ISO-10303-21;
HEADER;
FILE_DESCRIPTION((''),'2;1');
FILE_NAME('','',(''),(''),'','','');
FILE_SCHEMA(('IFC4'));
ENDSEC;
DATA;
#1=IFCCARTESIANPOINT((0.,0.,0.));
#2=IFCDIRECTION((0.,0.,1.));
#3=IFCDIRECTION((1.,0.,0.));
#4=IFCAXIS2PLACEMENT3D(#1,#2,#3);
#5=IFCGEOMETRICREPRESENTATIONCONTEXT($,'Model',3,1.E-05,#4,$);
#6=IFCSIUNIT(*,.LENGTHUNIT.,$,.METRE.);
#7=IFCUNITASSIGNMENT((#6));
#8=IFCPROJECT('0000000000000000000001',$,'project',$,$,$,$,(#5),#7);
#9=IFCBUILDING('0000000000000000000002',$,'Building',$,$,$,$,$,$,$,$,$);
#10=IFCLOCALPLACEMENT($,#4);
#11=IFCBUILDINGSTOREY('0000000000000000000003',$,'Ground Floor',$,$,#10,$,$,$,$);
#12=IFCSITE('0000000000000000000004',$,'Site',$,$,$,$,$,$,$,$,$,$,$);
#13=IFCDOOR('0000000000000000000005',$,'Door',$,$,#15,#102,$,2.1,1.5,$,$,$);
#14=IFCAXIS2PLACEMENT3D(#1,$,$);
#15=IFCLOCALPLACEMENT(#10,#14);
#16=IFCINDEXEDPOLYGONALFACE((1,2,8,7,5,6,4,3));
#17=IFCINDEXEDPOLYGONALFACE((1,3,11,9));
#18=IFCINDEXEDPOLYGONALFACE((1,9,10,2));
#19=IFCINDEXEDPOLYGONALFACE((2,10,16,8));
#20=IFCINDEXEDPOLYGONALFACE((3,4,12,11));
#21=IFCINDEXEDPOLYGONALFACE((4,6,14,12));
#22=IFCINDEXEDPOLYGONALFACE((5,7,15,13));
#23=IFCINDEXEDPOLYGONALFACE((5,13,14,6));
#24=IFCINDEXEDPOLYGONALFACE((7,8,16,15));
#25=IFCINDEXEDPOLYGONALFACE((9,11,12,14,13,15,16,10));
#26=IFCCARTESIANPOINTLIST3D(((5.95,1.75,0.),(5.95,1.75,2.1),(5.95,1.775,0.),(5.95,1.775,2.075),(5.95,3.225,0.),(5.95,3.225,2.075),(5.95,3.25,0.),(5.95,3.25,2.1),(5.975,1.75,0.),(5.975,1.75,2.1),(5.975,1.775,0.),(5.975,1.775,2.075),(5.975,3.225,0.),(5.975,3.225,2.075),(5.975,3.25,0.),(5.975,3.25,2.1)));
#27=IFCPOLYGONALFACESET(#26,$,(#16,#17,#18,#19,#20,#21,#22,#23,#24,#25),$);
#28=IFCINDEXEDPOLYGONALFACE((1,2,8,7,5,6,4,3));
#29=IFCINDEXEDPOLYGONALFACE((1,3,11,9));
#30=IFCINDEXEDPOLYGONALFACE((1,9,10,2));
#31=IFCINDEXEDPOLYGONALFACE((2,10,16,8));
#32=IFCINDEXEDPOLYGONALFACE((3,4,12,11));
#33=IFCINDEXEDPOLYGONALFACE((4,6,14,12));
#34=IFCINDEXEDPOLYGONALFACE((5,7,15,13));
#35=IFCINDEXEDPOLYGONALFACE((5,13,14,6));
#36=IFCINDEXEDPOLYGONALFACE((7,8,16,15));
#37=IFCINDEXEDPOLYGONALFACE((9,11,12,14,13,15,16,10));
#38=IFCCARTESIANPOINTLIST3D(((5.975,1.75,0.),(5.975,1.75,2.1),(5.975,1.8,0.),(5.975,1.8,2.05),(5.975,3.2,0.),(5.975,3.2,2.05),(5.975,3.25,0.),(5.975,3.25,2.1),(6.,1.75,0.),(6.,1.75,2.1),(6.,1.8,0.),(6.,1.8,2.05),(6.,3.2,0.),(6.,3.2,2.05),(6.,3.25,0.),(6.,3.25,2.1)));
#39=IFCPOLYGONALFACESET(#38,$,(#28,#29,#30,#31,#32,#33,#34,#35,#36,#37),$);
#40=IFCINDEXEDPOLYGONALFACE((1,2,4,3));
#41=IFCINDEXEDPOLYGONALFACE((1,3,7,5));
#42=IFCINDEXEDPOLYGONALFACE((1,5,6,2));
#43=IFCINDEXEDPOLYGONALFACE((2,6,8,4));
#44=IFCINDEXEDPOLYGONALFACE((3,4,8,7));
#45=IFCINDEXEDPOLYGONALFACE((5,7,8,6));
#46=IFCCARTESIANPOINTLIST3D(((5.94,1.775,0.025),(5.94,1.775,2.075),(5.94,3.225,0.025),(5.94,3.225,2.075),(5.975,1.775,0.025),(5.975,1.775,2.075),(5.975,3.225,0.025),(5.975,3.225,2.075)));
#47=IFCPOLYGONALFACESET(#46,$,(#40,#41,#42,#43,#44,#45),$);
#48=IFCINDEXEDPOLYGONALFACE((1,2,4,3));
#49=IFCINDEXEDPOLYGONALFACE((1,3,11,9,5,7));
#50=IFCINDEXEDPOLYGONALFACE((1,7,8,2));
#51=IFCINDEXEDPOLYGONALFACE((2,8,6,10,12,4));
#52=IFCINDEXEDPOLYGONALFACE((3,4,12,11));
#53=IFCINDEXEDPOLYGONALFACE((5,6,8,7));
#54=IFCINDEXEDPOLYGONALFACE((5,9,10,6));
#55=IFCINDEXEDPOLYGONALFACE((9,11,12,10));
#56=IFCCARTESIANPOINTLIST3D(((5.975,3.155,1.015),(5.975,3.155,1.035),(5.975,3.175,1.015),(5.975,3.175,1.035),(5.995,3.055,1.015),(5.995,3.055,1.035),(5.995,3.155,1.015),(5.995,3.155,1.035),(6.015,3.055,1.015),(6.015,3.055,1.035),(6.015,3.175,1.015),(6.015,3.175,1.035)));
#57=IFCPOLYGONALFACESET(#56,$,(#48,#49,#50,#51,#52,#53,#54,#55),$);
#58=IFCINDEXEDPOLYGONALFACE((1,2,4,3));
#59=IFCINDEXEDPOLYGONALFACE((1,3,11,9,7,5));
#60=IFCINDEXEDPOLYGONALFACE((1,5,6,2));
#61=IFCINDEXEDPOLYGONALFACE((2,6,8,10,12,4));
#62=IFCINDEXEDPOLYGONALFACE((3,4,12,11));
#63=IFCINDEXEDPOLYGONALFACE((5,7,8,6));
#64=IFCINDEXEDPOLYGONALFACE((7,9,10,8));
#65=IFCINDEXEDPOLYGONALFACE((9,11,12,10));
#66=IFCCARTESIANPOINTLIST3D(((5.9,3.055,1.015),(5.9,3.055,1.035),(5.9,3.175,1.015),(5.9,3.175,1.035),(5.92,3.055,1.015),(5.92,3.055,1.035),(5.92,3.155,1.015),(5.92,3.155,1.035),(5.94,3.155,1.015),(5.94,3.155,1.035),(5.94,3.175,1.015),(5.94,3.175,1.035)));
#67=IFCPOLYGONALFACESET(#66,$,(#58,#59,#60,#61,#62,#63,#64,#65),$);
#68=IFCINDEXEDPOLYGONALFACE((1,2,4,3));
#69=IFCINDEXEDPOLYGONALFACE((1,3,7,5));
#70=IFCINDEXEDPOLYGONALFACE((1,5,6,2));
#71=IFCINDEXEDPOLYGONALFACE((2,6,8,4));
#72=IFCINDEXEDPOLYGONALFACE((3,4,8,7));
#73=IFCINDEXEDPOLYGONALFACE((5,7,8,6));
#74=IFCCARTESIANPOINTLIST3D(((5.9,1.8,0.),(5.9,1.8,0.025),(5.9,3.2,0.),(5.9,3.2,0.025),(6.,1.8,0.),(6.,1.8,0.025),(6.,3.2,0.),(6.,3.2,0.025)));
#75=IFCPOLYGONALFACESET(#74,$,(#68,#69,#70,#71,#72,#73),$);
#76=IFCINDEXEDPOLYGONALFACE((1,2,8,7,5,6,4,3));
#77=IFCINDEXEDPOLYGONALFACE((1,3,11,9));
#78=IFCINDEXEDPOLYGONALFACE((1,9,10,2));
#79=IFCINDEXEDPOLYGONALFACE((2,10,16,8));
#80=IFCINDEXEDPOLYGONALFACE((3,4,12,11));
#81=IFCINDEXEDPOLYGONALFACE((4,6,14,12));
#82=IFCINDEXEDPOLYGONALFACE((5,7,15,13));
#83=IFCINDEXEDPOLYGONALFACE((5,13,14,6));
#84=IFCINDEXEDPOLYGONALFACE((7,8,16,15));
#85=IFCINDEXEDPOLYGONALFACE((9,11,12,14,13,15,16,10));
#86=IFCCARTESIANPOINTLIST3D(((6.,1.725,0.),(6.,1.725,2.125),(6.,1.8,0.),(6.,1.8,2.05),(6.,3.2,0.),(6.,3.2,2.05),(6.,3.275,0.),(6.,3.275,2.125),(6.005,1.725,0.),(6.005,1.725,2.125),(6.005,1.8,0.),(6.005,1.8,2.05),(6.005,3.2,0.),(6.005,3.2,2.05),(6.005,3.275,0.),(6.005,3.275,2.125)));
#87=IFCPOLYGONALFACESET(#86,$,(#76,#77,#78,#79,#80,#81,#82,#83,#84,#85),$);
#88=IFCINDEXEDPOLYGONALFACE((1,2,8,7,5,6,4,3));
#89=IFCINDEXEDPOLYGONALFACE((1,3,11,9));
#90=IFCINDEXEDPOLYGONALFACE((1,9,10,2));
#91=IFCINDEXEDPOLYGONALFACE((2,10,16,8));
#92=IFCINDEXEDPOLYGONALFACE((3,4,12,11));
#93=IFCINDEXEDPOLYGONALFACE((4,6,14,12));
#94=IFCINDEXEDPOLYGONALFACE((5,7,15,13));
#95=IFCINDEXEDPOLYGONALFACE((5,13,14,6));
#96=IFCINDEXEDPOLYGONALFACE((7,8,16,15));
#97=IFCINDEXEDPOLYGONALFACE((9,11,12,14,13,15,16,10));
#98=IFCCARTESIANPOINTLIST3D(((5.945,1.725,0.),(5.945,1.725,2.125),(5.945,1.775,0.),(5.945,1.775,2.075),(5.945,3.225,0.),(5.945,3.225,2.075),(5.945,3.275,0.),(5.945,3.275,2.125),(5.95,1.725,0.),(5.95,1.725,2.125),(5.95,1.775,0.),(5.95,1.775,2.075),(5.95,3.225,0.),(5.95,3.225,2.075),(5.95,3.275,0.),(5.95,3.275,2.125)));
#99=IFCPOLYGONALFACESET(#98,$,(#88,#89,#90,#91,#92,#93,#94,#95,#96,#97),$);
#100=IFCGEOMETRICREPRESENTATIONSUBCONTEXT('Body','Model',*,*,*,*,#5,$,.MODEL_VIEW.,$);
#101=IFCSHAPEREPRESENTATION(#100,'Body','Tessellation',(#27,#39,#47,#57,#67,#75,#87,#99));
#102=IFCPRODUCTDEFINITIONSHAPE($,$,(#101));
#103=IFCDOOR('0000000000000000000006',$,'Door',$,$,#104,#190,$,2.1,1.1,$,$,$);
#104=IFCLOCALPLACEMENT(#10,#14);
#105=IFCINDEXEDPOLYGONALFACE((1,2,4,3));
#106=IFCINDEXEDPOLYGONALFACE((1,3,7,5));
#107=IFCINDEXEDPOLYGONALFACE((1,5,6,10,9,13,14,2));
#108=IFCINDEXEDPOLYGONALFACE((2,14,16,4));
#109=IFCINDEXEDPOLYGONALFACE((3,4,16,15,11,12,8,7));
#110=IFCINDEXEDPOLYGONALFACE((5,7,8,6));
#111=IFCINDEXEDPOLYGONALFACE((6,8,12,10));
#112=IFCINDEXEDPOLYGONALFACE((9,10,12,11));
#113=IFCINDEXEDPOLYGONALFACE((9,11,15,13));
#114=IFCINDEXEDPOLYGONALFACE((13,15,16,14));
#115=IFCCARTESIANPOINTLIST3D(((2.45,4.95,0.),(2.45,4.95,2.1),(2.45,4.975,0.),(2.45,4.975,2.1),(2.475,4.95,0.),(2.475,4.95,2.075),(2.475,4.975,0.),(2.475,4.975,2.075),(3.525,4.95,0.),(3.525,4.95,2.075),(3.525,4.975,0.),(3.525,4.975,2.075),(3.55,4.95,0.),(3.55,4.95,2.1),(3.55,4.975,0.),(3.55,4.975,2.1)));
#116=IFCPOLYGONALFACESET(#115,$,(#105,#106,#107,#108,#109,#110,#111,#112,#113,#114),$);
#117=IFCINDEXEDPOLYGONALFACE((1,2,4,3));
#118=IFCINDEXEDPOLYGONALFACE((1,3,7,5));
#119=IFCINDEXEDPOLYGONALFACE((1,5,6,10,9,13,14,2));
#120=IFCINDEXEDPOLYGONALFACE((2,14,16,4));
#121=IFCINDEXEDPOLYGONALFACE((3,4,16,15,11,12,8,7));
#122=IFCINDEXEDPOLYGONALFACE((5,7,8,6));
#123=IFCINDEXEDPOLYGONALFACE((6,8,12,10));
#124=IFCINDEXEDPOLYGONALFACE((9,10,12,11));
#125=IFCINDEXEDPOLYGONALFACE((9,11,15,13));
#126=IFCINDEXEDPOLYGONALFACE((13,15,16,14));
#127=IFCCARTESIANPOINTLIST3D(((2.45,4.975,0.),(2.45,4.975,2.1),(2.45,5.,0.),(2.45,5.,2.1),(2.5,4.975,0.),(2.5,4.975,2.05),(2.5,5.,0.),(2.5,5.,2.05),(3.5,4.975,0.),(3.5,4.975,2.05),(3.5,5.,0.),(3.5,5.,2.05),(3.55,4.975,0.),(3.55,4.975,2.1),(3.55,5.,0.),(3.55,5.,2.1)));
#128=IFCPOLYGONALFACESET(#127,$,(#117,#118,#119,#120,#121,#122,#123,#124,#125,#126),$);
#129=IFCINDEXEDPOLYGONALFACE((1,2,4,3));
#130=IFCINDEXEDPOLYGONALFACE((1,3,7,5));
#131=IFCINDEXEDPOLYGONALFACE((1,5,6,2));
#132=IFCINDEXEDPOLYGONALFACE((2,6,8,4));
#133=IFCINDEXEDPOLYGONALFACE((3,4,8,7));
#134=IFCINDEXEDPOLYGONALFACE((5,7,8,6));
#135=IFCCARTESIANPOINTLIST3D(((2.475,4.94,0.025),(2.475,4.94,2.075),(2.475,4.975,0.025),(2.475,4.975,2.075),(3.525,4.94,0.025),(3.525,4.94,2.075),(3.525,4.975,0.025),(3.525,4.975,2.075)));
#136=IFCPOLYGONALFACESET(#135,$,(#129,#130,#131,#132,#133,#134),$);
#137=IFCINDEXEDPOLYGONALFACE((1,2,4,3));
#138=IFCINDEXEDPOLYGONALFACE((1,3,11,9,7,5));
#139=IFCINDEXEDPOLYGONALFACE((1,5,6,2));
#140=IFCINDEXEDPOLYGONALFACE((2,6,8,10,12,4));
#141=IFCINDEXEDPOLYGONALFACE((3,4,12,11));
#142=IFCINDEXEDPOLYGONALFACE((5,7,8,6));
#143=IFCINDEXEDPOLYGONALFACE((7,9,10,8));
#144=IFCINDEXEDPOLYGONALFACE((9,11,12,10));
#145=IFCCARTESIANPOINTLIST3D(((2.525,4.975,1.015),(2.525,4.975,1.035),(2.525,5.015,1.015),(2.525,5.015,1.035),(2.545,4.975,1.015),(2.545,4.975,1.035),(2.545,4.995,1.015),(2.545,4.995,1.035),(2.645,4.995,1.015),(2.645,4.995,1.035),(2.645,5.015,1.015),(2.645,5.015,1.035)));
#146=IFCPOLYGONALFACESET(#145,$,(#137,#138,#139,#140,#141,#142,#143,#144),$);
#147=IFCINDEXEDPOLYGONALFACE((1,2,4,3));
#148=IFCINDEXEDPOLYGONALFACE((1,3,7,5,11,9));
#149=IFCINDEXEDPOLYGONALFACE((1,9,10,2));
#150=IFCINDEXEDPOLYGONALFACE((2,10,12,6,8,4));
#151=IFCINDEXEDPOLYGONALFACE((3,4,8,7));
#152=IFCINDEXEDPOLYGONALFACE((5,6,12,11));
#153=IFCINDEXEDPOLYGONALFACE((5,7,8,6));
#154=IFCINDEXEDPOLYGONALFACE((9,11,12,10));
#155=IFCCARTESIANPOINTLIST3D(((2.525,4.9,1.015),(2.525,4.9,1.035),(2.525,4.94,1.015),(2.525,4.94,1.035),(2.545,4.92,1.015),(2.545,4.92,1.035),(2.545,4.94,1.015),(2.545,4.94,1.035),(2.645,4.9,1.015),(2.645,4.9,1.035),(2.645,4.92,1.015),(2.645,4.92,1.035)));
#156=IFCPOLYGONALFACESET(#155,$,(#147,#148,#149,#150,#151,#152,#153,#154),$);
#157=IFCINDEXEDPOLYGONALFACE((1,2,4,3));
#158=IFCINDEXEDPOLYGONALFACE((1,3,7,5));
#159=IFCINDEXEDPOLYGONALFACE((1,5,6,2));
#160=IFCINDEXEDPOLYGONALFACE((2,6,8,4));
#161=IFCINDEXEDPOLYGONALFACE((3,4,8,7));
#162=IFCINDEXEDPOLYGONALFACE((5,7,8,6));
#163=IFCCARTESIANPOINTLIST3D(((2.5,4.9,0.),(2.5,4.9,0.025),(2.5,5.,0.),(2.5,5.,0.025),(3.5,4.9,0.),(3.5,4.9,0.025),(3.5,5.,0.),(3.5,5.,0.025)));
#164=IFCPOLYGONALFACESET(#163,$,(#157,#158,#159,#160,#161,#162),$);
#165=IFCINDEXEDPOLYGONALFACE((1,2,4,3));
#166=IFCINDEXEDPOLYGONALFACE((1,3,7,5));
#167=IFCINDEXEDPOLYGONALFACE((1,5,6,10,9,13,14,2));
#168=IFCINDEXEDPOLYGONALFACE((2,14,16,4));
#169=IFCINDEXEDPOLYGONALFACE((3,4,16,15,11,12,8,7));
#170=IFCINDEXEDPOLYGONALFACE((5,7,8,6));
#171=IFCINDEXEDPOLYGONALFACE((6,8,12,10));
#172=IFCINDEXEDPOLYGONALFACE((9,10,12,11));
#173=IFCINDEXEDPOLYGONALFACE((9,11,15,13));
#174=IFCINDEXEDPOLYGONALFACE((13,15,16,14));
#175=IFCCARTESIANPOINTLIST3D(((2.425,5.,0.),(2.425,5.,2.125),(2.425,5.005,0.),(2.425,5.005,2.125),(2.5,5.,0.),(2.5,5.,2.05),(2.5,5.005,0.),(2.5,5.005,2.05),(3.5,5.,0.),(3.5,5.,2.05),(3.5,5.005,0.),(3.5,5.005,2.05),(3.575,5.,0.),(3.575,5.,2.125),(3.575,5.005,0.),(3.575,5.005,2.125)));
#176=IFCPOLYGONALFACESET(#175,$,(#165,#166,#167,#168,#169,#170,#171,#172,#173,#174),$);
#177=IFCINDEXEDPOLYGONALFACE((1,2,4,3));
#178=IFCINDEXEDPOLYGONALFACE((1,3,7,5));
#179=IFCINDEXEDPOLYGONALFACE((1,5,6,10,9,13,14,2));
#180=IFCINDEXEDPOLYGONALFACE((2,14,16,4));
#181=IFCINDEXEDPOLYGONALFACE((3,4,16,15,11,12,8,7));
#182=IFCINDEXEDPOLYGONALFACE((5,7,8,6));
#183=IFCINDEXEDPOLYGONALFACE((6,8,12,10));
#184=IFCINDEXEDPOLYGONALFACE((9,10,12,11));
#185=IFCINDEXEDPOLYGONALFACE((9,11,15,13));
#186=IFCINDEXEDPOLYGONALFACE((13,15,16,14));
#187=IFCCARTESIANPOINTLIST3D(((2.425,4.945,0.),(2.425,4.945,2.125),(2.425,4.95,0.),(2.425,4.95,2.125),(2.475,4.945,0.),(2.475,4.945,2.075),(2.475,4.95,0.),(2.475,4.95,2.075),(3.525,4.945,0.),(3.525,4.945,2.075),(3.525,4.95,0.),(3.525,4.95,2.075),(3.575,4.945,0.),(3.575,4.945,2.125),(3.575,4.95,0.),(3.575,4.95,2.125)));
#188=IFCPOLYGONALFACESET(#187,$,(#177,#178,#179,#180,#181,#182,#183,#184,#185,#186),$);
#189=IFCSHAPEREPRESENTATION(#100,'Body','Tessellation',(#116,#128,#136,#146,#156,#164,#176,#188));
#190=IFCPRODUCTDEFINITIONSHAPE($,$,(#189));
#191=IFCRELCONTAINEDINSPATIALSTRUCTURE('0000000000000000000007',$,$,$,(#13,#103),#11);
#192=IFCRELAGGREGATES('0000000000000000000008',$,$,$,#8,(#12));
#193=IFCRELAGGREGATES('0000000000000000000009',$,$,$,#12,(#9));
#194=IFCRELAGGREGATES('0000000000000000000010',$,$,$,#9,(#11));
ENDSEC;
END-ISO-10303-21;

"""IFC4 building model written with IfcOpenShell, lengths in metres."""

from ifc_helpers import new_model, si_unit, frame, origin_with_axes, place, context, subcontext, project, spatial, line, indexed_curve, outline, extrude, element, save


model = new_model("IFC4")

# Units and contexts
model_context = context("Model", 3, precision=1e-05, world=origin_with_axes())
body_context = subcontext(model_context, "Body", "Model", "MODEL_VIEW")
ifc_project = project(units=[si_unit("LENGTHUNIT", "METRE")], contexts=[model_context])

# Site, building, storey
site = spatial("IfcSite", under=ifc_project, Name="Site")
building = spatial("IfcBuilding", under=site, Name="Building")
storey_placement = place(None, origin_with_axes())
storey = spatial("IfcBuildingStorey", under=building, at=storey_placement, Name="Ground Floor")

# Doors
door_1_placement = place(storey_placement, frame((6.0, 1.75, 0.0), z_axis=(0.0, 0.0, 1.0), x_axis=(0.0, 1.0, 0.0)))
element("IfcDoor", 1, at=door_1_placement, inside=storey, Name="Door", OverallHeight=2.1, OverallWidth=1.5, context=body_context, shape_type="SweptSolid", body=[
    extrude(outline(indexed_curve([(0.0, 0.0), (0.0, 2.1), (1.5, 2.1), (1.5, 0.0), (1.475, 0.0), (1.475, 2.075), (0.025, 2.075), (0.025, 0.0)], segments=[line(1, 2, 3, 4, 5, 6, 7, 8, 1)])), frame((0.0, 0.025, 0.0), z_axis=(0.0, -1.0, 0.0), x_axis=(1.0, 0.0, 0.0)), (0.0, 0.0, -1.0), 0.025),
    extrude(outline(indexed_curve([(0.0, 0.0), (0.0, 2.1), (1.5, 2.1), (1.5, 0.0), (1.45, 0.0), (1.45, 2.05), (0.05, 2.05), (0.05, 0.0)], segments=[line(1, 2, 3, 4, 5, 6, 7, 8, 1)])), frame((0.0, 0.0, 0.0), z_axis=(0.0, -1.0, 0.0), x_axis=(1.0, 0.0, 0.0)), (0.0, 0.0, -1.0), 0.025),
    extrude(outline(indexed_curve([(0.0, 0.0), (1.45, 0.0), (1.45, 0.035), (0.0, 0.035)], segments=[line(1, 2, 3, 4, 1)])), frame((0.025, 0.025, 0.025), z_axis=(0.0, 0.0, 1.0), x_axis=(1.0, 0.0, 0.0)), (0.0, 0.0, 1.0), 2.05),
    extrude(outline(indexed_curve([(0.0, 0.0), (0.0, -0.04), (-0.12, -0.04), (-0.12, -0.02), (-0.02, -0.02), (-0.02, 0.0)], segments=[line(1, 2, 3, 4, 5, 6, 1)])), frame((1.425, 0.025, 1.015), z_axis=(0.0, 0.0, 1.0), x_axis=(1.0, 0.0, 0.0)), (0.0, 0.0, 1.0), 0.02),
    extrude(outline(indexed_curve([(0.0, 0.0), (0.0, 0.04), (-0.12, 0.04), (-0.12, 0.02), (-0.02, 0.02), (-0.02, 0.0)], segments=[line(1, 2, 3, 4, 5, 6, 1)])), frame((1.425, 0.06, 1.015), z_axis=(0.0, 0.0, 1.0), x_axis=(1.0, 0.0, 0.0)), (0.0, 0.0, 1.0), 0.02),
    extrude(outline(indexed_curve([(0.0, 0.0), (1.4, 0.0), (1.4, 0.1), (0.0, 0.1)], segments=[line(1, 2, 3, 4, 1)])), frame((0.05, 0.0, 0.0), z_axis=(0.0, 0.0, 1.0), x_axis=(1.0, 0.0, 0.0)), (0.0, 0.0, 1.0), 0.025),
    extrude(outline(indexed_curve([(0.0, 0.0), (0.0, 2.125), (1.55, 2.125), (1.55, 0.0), (1.475, 0.0), (1.475, 2.05), (0.075, 2.05), (0.075, 0.0)], segments=[line(1, 2, 3, 4, 5, 6, 7, 8, 1)])), frame((-0.025, -0.005, 0.0), z_axis=(0.0, -1.0, 0.0), x_axis=(1.0, 0.0, 0.0)), (0.0, 0.0, -1.0), 0.005),
    extrude(outline(indexed_curve([(0.0, 0.0), (0.0, 2.125), (1.55, 2.125), (1.55, 0.0), (1.5, 0.0), (1.5, 2.075), (0.05, 2.075), (0.05, 0.0)], segments=[line(1, 2, 3, 4, 5, 6, 7, 8, 1)])), frame((-0.025, 0.05, 0.0), z_axis=(0.0, -1.0, 0.0), x_axis=(1.0, 0.0, 0.0)), (0.0, 0.0, -1.0), 0.005),
])
door_2_placement = place(storey_placement, frame((3.55, 5.0, 0.0), z_axis=(0.0, 0.0, 1.0), x_axis=(-1.0, 0.0, 0.0)))
element("IfcDoor", 2, at=door_2_placement, inside=storey, Name="Door", OverallHeight=2.1, OverallWidth=1.1, context=body_context, shape_type="SweptSolid", body=[
    extrude(outline(indexed_curve([(0.0, 0.0), (0.0, 2.1), (1.1, 2.1), (1.1, 0.0), (1.075, 0.0), (1.075, 2.075), (0.025, 2.075), (0.025, 0.0)], segments=[line(1, 2, 3, 4, 5, 6, 7, 8, 1)])), frame((0.0, 0.025, 0.0), z_axis=(0.0, -1.0, 0.0), x_axis=(1.0, 0.0, 0.0)), (0.0, 0.0, -1.0), 0.025),
    extrude(outline(indexed_curve([(0.0, 0.0), (0.0, 2.1), (1.1, 2.1), (1.1, 0.0), (1.05, 0.0), (1.05, 2.05), (0.05, 2.05), (0.05, 0.0)], segments=[line(1, 2, 3, 4, 5, 6, 7, 8, 1)])), frame((0.0, 0.0, 0.0), z_axis=(0.0, -1.0, 0.0), x_axis=(1.0, 0.0, 0.0)), (0.0, 0.0, -1.0), 0.025),
    extrude(outline(indexed_curve([(0.0, 0.0), (1.05, 0.0), (1.05, 0.035), (0.0, 0.035)], segments=[line(1, 2, 3, 4, 1)])), frame((0.025, 0.025, 0.025), z_axis=(0.0, 0.0, 1.0), x_axis=(1.0, 0.0, 0.0)), (0.0, 0.0, 1.0), 2.05),
    extrude(outline(indexed_curve([(0.0, 0.0), (0.0, -0.04), (-0.12, -0.04), (-0.12, -0.02), (-0.02, -0.02), (-0.02, 0.0)], segments=[line(1, 2, 3, 4, 5, 6, 1)])), frame((1.025, 0.025, 1.015), z_axis=(0.0, 0.0, 1.0), x_axis=(1.0, 0.0, 0.0)), (0.0, 0.0, 1.0), 0.02),
    extrude(outline(indexed_curve([(0.0, 0.0), (0.0, 0.04), (-0.12, 0.04), (-0.12, 0.02), (-0.02, 0.02), (-0.02, 0.0)], segments=[line(1, 2, 3, 4, 5, 6, 1)])), frame((1.025, 0.06, 1.015), z_axis=(0.0, 0.0, 1.0), x_axis=(1.0, 0.0, 0.0)), (0.0, 0.0, 1.0), 0.02),
    extrude(outline(indexed_curve([(0.0, 0.0), (1.0, 0.0), (1.0, 0.1), (0.0, 0.1)], segments=[line(1, 2, 3, 4, 1)])), frame((0.05, 0.0, 0.0), z_axis=(0.0, 0.0, 1.0), x_axis=(1.0, 0.0, 0.0)), (0.0, 0.0, 1.0), 0.025),
    extrude(outline(indexed_curve([(0.0, 0.0), (0.0, 2.125), (1.15, 2.125), (1.15, 0.0), (1.075, 0.0), (1.075, 2.05), (0.075, 2.05), (0.075, 0.0)], segments=[line(1, 2, 3, 4, 5, 6, 7, 8, 1)])), frame((-0.025, -0.005, 0.0), z_axis=(0.0, -1.0, 0.0), x_axis=(1.0, 0.0, 0.0)), (0.0, 0.0, -1.0), 0.005),
    extrude(outline(indexed_curve([(0.0, 0.0), (0.0, 2.125), (1.15, 2.125), (1.15, 0.0), (1.1, 0.0), (1.1, 2.075), (0.05, 2.075), (0.05, 0.0)], segments=[line(1, 2, 3, 4, 5, 6, 7, 8, 1)])), frame((-0.025, 0.05, 0.0), z_axis=(0.0, -1.0, 0.0), x_axis=(1.0, 0.0, 0.0)), (0.0, 0.0, -1.0), 0.005),
])

save(model, "model.ifc")
